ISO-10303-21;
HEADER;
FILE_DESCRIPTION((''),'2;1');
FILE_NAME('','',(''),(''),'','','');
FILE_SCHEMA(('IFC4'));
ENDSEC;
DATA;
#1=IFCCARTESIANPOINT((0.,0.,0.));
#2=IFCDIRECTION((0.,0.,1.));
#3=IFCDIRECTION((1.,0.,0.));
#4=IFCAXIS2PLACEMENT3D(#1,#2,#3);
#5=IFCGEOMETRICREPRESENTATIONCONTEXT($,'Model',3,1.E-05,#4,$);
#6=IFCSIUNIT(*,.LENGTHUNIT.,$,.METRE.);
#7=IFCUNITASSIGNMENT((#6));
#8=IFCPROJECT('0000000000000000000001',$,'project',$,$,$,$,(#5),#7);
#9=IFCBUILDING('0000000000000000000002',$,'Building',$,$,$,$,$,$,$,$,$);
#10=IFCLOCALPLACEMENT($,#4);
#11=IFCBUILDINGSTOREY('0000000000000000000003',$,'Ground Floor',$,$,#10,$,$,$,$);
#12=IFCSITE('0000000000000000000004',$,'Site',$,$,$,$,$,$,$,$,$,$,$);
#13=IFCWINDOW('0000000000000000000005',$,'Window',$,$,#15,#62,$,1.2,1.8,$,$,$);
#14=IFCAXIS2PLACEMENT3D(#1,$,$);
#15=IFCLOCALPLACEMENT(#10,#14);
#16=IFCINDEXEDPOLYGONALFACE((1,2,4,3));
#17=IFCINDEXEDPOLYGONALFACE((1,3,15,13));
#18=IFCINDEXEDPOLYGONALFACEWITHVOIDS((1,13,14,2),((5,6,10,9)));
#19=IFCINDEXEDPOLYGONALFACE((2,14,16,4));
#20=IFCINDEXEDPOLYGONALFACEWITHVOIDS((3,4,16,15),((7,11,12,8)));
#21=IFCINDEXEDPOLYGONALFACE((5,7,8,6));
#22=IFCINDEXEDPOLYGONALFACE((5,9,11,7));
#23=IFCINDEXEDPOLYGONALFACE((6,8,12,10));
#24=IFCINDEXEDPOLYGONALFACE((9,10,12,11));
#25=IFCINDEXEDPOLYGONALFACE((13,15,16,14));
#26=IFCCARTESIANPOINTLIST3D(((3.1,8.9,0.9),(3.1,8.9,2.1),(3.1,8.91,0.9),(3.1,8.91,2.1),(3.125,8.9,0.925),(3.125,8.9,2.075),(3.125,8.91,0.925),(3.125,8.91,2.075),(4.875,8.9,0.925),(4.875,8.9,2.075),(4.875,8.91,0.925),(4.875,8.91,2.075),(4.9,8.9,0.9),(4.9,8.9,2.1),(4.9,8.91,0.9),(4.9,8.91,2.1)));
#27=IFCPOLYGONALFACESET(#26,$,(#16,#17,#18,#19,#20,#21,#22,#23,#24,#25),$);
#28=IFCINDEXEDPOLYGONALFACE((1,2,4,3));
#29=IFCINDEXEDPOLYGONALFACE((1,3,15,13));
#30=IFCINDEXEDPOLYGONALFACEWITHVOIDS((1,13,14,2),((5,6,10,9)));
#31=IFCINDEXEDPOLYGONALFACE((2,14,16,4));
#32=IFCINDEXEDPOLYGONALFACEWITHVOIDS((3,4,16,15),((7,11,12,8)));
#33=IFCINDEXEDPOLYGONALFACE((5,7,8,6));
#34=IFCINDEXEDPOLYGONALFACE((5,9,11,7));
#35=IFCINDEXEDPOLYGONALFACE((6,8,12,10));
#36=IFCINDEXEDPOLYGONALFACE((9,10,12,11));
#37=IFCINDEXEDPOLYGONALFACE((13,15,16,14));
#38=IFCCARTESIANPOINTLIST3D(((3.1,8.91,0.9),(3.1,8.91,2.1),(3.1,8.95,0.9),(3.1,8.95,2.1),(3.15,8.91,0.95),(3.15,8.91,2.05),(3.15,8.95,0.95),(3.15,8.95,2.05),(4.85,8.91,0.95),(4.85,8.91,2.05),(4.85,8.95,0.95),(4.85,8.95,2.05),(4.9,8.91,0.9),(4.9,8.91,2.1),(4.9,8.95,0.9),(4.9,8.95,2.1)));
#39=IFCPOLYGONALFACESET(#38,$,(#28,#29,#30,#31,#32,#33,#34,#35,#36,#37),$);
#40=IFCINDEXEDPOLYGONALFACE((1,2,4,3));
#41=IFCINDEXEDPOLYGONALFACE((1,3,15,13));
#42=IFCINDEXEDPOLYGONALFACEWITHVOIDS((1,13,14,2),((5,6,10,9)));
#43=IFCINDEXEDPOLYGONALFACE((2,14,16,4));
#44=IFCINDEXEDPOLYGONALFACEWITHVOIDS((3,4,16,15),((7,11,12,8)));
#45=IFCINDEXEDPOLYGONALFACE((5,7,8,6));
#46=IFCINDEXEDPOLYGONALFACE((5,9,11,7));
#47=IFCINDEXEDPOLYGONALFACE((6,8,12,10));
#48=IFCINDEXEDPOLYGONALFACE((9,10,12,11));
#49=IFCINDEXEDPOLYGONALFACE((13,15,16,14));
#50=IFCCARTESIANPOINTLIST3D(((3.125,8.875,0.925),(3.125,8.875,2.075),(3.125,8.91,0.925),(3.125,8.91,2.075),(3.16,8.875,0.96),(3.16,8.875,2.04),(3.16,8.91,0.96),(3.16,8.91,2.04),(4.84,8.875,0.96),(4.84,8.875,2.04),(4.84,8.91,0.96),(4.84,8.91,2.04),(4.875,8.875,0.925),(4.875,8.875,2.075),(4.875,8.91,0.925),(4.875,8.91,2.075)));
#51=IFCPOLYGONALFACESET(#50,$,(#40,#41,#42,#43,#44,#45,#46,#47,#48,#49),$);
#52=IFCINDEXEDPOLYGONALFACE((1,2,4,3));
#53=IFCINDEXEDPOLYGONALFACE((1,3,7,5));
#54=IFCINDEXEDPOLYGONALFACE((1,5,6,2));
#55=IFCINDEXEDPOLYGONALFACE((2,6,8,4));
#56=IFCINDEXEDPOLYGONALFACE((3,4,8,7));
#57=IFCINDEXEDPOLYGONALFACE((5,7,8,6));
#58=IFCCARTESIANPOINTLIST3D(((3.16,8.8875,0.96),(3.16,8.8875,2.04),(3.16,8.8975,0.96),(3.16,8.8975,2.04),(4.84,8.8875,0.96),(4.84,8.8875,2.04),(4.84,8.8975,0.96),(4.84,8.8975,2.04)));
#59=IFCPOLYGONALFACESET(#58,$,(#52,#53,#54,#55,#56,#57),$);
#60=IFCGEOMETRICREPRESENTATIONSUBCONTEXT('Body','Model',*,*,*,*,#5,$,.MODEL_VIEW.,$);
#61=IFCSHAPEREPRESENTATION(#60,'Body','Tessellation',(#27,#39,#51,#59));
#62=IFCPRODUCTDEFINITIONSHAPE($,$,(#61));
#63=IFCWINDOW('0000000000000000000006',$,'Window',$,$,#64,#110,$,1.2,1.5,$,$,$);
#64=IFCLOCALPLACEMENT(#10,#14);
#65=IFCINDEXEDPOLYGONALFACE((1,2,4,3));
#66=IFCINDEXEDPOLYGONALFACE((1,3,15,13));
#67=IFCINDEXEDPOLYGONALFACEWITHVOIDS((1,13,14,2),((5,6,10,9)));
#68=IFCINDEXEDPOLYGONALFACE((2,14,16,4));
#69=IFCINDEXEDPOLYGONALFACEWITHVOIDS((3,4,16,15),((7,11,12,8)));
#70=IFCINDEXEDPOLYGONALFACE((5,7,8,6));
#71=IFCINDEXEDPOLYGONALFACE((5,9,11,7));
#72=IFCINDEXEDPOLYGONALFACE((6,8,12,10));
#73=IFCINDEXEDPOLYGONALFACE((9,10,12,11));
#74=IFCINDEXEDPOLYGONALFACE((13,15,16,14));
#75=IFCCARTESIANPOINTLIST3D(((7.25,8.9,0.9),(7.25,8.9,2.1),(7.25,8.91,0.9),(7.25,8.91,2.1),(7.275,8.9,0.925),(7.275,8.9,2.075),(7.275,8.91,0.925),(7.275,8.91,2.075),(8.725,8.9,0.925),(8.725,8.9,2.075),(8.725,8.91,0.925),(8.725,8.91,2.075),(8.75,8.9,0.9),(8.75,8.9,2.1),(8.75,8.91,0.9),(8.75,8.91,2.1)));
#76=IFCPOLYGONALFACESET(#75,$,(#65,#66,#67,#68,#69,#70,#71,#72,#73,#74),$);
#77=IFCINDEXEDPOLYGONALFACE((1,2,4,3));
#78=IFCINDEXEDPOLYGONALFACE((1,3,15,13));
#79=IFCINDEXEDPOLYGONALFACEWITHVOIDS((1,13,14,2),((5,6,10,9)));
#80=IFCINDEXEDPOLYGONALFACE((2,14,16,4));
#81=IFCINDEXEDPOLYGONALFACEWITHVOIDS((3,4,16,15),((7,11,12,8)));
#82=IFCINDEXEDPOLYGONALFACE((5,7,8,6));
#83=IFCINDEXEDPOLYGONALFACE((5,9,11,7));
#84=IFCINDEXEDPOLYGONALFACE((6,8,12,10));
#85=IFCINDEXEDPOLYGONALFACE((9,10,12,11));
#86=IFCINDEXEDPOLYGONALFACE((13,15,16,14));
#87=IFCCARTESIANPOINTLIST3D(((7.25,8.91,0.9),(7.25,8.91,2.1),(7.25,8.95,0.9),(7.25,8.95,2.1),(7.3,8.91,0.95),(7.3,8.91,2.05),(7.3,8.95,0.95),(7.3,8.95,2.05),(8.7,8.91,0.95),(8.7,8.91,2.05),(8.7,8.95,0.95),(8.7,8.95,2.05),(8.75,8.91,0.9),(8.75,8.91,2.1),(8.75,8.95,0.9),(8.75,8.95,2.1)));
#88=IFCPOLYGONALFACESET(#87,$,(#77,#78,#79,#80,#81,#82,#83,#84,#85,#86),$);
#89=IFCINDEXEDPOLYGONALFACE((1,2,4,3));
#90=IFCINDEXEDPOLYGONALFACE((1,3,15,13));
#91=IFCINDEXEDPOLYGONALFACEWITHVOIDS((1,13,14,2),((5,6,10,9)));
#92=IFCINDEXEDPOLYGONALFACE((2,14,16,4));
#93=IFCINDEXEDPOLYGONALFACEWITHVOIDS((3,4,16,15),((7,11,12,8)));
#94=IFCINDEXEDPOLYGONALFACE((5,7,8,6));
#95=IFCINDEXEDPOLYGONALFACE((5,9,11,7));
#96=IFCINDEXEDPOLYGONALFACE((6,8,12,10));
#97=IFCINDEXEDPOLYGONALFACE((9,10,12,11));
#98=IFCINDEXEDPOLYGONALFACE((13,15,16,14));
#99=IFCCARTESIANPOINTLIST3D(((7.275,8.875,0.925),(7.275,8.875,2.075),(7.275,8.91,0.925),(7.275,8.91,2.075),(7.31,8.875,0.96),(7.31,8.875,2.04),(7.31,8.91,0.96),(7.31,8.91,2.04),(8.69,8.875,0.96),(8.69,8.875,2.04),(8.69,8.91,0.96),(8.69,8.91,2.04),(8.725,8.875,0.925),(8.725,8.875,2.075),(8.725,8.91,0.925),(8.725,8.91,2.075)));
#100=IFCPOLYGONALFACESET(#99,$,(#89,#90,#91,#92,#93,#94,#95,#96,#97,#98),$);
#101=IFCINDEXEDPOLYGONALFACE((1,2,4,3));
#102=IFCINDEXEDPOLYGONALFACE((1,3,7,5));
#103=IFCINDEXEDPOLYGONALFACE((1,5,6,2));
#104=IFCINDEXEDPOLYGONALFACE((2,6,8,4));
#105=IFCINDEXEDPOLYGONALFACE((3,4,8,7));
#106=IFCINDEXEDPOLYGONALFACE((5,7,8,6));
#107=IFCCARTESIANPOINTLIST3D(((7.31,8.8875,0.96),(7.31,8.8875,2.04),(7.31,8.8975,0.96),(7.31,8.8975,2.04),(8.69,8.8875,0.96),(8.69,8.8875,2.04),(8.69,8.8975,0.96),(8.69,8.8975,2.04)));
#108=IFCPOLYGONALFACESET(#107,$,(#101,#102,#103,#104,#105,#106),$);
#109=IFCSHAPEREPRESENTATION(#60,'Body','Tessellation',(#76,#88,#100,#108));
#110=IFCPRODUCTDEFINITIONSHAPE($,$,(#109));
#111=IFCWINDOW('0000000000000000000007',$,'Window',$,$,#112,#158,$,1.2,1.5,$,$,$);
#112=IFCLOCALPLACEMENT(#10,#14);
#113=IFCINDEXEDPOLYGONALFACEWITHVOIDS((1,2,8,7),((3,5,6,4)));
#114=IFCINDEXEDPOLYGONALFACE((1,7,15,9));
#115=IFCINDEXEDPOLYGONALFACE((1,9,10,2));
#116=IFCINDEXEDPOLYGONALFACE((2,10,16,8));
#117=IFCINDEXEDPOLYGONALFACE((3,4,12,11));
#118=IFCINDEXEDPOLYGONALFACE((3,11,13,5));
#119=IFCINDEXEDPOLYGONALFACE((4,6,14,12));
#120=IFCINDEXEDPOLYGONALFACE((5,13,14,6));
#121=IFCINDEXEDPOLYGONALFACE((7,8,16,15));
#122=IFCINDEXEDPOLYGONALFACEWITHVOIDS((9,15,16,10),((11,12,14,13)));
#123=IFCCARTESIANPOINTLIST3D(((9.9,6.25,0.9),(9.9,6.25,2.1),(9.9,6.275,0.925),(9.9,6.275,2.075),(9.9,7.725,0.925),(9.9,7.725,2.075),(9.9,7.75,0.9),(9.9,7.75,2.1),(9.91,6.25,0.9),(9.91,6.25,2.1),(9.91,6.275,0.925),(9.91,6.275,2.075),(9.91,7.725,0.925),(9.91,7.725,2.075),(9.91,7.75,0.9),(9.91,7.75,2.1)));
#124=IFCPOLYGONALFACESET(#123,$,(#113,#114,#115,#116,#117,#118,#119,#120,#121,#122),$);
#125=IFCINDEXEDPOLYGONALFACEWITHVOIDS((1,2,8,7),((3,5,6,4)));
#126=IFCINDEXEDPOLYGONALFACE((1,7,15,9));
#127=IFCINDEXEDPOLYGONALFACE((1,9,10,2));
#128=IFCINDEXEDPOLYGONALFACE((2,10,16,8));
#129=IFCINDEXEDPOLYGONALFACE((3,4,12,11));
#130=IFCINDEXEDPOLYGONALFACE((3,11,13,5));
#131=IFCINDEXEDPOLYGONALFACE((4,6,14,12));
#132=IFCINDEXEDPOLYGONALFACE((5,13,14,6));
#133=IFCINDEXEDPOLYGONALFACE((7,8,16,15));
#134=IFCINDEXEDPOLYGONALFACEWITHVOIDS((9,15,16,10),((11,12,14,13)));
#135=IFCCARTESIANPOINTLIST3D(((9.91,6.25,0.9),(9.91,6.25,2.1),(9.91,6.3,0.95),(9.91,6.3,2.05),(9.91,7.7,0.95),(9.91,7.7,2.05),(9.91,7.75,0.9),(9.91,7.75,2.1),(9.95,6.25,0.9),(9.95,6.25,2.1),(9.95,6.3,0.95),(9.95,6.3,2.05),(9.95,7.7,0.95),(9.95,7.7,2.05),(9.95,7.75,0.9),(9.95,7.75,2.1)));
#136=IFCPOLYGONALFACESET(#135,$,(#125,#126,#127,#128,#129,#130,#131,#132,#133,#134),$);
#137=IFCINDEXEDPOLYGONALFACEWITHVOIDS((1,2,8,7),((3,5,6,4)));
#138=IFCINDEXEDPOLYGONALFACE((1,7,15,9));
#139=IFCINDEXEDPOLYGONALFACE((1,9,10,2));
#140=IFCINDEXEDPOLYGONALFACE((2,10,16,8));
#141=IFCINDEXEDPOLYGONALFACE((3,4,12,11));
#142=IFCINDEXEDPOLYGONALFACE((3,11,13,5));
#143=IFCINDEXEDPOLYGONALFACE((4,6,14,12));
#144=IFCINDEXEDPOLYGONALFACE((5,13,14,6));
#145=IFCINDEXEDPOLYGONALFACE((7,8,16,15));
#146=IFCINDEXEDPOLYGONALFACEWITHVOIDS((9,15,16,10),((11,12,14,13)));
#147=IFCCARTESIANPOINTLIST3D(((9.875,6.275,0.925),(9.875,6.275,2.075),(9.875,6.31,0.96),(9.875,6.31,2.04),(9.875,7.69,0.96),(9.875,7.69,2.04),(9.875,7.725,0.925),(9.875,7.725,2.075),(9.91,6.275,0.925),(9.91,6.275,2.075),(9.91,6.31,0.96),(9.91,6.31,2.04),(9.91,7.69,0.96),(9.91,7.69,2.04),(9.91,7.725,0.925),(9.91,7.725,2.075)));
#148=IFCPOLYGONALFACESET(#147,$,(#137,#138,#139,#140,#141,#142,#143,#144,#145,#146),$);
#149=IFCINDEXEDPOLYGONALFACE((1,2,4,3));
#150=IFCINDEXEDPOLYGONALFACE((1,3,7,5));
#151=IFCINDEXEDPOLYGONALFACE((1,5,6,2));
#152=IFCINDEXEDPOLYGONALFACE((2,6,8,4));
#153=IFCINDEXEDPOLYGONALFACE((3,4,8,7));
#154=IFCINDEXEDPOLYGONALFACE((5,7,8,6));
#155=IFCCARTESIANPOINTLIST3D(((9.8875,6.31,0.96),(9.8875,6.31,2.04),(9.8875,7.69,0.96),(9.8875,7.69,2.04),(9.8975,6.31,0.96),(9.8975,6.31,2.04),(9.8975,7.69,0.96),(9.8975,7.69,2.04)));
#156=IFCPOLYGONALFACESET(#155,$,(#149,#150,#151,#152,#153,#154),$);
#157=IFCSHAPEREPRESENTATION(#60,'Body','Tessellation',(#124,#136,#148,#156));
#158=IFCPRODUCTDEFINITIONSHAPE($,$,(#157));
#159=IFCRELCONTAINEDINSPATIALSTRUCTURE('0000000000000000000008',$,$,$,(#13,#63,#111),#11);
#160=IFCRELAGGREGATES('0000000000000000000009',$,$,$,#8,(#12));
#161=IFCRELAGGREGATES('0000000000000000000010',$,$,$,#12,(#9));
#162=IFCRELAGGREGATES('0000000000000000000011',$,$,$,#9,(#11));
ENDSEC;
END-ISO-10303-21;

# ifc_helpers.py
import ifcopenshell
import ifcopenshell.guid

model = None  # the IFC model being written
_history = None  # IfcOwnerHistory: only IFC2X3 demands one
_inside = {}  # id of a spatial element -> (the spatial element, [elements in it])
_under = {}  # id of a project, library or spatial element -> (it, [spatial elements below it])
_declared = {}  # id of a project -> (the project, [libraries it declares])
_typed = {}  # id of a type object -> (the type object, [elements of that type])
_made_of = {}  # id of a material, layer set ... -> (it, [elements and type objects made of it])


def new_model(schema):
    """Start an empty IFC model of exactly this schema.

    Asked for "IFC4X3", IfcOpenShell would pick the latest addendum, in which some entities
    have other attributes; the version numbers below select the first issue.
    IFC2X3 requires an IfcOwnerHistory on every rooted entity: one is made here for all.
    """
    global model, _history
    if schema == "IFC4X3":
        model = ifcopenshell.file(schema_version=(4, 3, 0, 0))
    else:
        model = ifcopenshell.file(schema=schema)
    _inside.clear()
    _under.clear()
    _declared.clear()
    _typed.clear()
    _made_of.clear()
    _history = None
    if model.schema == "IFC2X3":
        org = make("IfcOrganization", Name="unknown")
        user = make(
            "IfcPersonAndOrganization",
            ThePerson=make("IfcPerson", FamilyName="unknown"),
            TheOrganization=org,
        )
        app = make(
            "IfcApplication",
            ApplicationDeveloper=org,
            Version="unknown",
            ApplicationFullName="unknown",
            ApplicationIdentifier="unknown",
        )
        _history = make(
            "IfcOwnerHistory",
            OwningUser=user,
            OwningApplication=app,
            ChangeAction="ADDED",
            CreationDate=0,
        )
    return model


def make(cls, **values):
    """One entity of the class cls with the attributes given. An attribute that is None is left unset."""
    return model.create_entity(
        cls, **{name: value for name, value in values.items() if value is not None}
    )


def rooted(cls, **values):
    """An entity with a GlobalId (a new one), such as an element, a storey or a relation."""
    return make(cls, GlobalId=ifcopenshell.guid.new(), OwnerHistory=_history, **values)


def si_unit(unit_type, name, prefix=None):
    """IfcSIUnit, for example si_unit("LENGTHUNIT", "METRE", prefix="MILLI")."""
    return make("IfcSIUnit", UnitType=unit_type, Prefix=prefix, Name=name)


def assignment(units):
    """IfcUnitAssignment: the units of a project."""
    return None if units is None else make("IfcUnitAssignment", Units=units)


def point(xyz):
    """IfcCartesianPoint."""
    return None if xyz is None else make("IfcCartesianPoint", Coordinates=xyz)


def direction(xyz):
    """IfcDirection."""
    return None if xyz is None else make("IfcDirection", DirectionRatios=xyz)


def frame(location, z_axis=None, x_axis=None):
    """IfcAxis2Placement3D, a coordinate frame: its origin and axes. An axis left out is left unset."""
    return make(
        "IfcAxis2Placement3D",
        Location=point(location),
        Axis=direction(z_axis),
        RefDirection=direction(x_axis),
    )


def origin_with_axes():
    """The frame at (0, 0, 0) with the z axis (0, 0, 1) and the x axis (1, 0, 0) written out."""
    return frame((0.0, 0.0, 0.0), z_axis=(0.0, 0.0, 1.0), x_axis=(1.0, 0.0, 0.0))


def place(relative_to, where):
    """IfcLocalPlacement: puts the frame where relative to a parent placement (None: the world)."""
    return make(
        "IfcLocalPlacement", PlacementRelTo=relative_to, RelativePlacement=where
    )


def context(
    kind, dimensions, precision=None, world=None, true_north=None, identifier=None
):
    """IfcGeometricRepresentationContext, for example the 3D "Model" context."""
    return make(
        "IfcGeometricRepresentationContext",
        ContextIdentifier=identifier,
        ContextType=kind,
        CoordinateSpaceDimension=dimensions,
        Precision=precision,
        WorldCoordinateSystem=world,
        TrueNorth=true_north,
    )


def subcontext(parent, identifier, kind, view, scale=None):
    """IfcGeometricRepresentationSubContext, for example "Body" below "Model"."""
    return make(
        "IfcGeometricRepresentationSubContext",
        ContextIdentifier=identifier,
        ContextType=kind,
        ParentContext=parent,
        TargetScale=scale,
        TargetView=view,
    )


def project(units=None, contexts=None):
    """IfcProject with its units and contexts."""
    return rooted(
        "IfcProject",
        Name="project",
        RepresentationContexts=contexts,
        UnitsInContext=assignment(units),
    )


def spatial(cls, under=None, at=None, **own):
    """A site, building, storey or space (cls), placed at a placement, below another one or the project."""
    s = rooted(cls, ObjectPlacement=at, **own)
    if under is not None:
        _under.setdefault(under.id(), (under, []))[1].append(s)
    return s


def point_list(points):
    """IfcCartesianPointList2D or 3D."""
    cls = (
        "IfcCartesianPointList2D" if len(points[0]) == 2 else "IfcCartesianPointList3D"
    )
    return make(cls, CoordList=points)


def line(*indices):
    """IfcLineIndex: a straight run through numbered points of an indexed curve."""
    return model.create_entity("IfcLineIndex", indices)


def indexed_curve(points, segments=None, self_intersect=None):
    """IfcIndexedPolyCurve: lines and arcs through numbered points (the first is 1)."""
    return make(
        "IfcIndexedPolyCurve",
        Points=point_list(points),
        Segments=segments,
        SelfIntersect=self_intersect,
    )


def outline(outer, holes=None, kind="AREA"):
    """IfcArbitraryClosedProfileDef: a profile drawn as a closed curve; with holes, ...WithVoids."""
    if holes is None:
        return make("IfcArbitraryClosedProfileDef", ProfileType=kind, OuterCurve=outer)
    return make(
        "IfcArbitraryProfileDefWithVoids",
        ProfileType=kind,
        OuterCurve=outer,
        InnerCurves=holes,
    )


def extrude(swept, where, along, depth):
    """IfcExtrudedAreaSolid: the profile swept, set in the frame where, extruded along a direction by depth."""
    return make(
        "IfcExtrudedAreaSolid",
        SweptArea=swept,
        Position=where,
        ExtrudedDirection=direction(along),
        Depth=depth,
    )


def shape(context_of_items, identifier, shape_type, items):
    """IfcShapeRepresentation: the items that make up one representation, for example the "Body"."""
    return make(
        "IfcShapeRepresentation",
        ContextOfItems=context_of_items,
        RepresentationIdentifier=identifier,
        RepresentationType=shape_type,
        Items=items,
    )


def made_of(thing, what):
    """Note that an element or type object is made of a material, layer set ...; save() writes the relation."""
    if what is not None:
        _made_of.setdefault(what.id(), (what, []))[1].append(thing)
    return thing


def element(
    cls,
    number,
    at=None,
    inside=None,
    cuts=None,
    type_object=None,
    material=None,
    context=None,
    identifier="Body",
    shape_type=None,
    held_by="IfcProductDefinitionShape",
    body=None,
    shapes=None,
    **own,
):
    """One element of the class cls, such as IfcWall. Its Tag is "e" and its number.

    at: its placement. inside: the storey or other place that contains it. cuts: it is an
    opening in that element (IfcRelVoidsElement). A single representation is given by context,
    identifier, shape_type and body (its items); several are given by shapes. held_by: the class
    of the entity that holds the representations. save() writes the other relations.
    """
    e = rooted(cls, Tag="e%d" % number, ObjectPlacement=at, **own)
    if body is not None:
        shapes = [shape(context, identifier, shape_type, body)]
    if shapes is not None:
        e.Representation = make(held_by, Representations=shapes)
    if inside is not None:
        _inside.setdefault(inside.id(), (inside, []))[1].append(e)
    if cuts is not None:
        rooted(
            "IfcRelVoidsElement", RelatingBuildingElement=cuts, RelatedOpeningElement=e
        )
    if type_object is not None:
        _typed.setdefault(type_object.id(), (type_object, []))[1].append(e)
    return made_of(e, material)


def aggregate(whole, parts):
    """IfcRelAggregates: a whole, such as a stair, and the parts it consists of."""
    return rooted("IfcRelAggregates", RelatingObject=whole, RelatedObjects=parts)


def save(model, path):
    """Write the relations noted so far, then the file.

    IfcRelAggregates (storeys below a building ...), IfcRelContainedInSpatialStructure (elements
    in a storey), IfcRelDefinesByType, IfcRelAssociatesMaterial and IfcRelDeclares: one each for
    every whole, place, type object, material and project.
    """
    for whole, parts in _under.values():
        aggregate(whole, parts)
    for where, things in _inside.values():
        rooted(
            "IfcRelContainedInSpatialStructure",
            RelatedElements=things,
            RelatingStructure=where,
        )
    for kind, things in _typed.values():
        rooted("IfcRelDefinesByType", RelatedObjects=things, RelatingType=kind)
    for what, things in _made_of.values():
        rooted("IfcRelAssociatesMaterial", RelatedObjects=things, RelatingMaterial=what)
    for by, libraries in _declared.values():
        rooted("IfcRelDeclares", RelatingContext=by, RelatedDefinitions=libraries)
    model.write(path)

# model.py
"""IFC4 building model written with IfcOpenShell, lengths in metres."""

from ifc_helpers import new_model, si_unit, frame, origin_with_axes, place, context, subcontext, project, spatial, line, indexed_curve, outline, extrude, element, save


model = new_model("IFC4")

# Units and contexts
model_context = context("Model", 3, precision=1e-05, world=origin_with_axes())
body_context = subcontext(model_context, "Body", "Model", "MODEL_VIEW")
ifc_project = project(units=[si_unit("LENGTHUNIT", "METRE")], contexts=[model_context])

# Site, building, storey
site = spatial("IfcSite", under=ifc_project, Name="Site")
building = spatial("IfcBuilding", under=site, Name="Building")
storey_placement = place(None, origin_with_axes())
storey = spatial("IfcBuildingStorey", under=building, at=storey_placement, Name="Ground Floor")

# Windows
window_1_placement = place(storey_placement, frame((4.9, 9.0, 0.9), z_axis=(0.0, 0.0, 1.0), x_axis=(-1.0, 0.0, 0.0)))
element("IfcWindow", 1, at=window_1_placement, inside=storey, Name="Window", OverallHeight=1.2, OverallWidth=1.8, context=body_context, shape_type="SweptSolid", body=[
    extrude(outline(indexed_curve([(0.0, 0.0), (1.8, 0.0), (1.8, 1.2), (0.0, 1.2)], segments=[line(1, 2, 3, 4, 1)]), holes=[indexed_curve([(0.025, 0.025), (1.775, 0.025), (1.775, 1.175), (0.025, 1.175)], segments=[line(1, 2, 3, 4, 1)])]), frame((0.0, 0.09, 0.0), z_axis=(0.0, -1.0, 0.0), x_axis=(1.0, 0.0, 0.0)), (0.0, 0.0, -1.0), 0.01),
    extrude(outline(indexed_curve([(0.0, 0.0), (1.8, 0.0), (1.8, 1.2), (0.0, 1.2)], segments=[line(1, 2, 3, 4, 1)]), holes=[indexed_curve([(0.05, 0.05), (1.75, 0.05), (1.75, 1.15), (0.05, 1.15)], segments=[line(1, 2, 3, 4, 1)])]), frame((0.0, 0.05, 0.0), z_axis=(0.0, -1.0, 0.0), x_axis=(1.0, 0.0, 0.0)), (0.0, 0.0, -1.0), 0.04),
    extrude(outline(indexed_curve([(0.0, 0.0), (1.75, 0.0), (1.75, 1.15), (0.0, 1.15)], segments=[line(1, 2, 3, 4, 1)]), holes=[indexed_curve([(0.035, 0.035), (1.715, 0.035), (1.715, 1.115), (0.035, 1.115)], segments=[line(1, 2, 3, 4, 1)])]), frame((0.025, 0.09, 0.025), z_axis=(0.0, -1.0, 0.0), x_axis=(1.0, 0.0, 0.0)), (0.0, 0.0, -1.0), 0.035),
    extrude(outline(indexed_curve([(0.035, 0.035), (1.715, 0.035), (1.715, 1.115), (0.035, 1.115)], segments=[line(1, 2, 3, 4, 1)])), frame((0.025, 0.1025, 0.025), z_axis=(0.0, -1.0, 0.0), x_axis=(1.0, 0.0, 0.0)), (0.0, 0.0, -1.0), 0.01),
])
for number, where, z_axis, x_axis, name in (
    (2, (8.75, 9.0, 0.9), (0.0, 0.0, 1.0), (-1.0, 0.0, 0.0), "Window"),
    (3, (10.0, 6.25, 0.9), (0.0, 0.0, 1.0), (0.0, 1.0, 0.0), "Window"),
):
    element("IfcWindow", number, at=place(storey_placement, frame(where, z_axis=z_axis, x_axis=x_axis)), inside=storey, Name=name, OverallHeight=1.2, OverallWidth=1.5, context=body_context, shape_type="SweptSolid", body=[
        extrude(outline(indexed_curve([(0.0, 0.0), (1.5, 0.0), (1.5, 1.2), (0.0, 1.2)], segments=[line(1, 2, 3, 4, 1)]), holes=[indexed_curve([(0.025, 0.025), (1.475, 0.025), (1.475, 1.175), (0.025, 1.175)], segments=[line(1, 2, 3, 4, 1)])]), frame((0.0, 0.09, 0.0), z_axis=(0.0, -1.0, 0.0), x_axis=(1.0, 0.0, 0.0)), (0.0, 0.0, -1.0), 0.01),
        extrude(outline(indexed_curve([(0.0, 0.0), (1.5, 0.0), (1.5, 1.2), (0.0, 1.2)], segments=[line(1, 2, 3, 4, 1)]), holes=[indexed_curve([(0.05, 0.05), (1.45, 0.05), (1.45, 1.15), (0.05, 1.15)], segments=[line(1, 2, 3, 4, 1)])]), frame((0.0, 0.05, 0.0), z_axis=(0.0, -1.0, 0.0), x_axis=(1.0, 0.0, 0.0)), (0.0, 0.0, -1.0), 0.04),
        extrude(outline(indexed_curve([(0.0, 0.0), (1.45, 0.0), (1.45, 1.15), (0.0, 1.15)], segments=[line(1, 2, 3, 4, 1)]), holes=[indexed_curve([(0.035, 0.035), (1.415, 0.035), (1.415, 1.115), (0.035, 1.115)], segments=[line(1, 2, 3, 4, 1)])]), frame((0.025, 0.09, 0.025), z_axis=(0.0, -1.0, 0.0), x_axis=(1.0, 0.0, 0.0)), (0.0, 0.0, -1.0), 0.035),
        extrude(outline(indexed_curve([(0.035, 0.035), (1.415, 0.035), (1.415, 1.115), (0.035, 1.115)], segments=[line(1, 2, 3, 4, 1)])), frame((0.025, 0.1025, 0.025), z_axis=(0.0, -1.0, 0.0), x_axis=(1.0, 0.0, 0.0)), (0.0, 0.0, -1.0), 0.01),
    ])

save(model, "model.ifc")
